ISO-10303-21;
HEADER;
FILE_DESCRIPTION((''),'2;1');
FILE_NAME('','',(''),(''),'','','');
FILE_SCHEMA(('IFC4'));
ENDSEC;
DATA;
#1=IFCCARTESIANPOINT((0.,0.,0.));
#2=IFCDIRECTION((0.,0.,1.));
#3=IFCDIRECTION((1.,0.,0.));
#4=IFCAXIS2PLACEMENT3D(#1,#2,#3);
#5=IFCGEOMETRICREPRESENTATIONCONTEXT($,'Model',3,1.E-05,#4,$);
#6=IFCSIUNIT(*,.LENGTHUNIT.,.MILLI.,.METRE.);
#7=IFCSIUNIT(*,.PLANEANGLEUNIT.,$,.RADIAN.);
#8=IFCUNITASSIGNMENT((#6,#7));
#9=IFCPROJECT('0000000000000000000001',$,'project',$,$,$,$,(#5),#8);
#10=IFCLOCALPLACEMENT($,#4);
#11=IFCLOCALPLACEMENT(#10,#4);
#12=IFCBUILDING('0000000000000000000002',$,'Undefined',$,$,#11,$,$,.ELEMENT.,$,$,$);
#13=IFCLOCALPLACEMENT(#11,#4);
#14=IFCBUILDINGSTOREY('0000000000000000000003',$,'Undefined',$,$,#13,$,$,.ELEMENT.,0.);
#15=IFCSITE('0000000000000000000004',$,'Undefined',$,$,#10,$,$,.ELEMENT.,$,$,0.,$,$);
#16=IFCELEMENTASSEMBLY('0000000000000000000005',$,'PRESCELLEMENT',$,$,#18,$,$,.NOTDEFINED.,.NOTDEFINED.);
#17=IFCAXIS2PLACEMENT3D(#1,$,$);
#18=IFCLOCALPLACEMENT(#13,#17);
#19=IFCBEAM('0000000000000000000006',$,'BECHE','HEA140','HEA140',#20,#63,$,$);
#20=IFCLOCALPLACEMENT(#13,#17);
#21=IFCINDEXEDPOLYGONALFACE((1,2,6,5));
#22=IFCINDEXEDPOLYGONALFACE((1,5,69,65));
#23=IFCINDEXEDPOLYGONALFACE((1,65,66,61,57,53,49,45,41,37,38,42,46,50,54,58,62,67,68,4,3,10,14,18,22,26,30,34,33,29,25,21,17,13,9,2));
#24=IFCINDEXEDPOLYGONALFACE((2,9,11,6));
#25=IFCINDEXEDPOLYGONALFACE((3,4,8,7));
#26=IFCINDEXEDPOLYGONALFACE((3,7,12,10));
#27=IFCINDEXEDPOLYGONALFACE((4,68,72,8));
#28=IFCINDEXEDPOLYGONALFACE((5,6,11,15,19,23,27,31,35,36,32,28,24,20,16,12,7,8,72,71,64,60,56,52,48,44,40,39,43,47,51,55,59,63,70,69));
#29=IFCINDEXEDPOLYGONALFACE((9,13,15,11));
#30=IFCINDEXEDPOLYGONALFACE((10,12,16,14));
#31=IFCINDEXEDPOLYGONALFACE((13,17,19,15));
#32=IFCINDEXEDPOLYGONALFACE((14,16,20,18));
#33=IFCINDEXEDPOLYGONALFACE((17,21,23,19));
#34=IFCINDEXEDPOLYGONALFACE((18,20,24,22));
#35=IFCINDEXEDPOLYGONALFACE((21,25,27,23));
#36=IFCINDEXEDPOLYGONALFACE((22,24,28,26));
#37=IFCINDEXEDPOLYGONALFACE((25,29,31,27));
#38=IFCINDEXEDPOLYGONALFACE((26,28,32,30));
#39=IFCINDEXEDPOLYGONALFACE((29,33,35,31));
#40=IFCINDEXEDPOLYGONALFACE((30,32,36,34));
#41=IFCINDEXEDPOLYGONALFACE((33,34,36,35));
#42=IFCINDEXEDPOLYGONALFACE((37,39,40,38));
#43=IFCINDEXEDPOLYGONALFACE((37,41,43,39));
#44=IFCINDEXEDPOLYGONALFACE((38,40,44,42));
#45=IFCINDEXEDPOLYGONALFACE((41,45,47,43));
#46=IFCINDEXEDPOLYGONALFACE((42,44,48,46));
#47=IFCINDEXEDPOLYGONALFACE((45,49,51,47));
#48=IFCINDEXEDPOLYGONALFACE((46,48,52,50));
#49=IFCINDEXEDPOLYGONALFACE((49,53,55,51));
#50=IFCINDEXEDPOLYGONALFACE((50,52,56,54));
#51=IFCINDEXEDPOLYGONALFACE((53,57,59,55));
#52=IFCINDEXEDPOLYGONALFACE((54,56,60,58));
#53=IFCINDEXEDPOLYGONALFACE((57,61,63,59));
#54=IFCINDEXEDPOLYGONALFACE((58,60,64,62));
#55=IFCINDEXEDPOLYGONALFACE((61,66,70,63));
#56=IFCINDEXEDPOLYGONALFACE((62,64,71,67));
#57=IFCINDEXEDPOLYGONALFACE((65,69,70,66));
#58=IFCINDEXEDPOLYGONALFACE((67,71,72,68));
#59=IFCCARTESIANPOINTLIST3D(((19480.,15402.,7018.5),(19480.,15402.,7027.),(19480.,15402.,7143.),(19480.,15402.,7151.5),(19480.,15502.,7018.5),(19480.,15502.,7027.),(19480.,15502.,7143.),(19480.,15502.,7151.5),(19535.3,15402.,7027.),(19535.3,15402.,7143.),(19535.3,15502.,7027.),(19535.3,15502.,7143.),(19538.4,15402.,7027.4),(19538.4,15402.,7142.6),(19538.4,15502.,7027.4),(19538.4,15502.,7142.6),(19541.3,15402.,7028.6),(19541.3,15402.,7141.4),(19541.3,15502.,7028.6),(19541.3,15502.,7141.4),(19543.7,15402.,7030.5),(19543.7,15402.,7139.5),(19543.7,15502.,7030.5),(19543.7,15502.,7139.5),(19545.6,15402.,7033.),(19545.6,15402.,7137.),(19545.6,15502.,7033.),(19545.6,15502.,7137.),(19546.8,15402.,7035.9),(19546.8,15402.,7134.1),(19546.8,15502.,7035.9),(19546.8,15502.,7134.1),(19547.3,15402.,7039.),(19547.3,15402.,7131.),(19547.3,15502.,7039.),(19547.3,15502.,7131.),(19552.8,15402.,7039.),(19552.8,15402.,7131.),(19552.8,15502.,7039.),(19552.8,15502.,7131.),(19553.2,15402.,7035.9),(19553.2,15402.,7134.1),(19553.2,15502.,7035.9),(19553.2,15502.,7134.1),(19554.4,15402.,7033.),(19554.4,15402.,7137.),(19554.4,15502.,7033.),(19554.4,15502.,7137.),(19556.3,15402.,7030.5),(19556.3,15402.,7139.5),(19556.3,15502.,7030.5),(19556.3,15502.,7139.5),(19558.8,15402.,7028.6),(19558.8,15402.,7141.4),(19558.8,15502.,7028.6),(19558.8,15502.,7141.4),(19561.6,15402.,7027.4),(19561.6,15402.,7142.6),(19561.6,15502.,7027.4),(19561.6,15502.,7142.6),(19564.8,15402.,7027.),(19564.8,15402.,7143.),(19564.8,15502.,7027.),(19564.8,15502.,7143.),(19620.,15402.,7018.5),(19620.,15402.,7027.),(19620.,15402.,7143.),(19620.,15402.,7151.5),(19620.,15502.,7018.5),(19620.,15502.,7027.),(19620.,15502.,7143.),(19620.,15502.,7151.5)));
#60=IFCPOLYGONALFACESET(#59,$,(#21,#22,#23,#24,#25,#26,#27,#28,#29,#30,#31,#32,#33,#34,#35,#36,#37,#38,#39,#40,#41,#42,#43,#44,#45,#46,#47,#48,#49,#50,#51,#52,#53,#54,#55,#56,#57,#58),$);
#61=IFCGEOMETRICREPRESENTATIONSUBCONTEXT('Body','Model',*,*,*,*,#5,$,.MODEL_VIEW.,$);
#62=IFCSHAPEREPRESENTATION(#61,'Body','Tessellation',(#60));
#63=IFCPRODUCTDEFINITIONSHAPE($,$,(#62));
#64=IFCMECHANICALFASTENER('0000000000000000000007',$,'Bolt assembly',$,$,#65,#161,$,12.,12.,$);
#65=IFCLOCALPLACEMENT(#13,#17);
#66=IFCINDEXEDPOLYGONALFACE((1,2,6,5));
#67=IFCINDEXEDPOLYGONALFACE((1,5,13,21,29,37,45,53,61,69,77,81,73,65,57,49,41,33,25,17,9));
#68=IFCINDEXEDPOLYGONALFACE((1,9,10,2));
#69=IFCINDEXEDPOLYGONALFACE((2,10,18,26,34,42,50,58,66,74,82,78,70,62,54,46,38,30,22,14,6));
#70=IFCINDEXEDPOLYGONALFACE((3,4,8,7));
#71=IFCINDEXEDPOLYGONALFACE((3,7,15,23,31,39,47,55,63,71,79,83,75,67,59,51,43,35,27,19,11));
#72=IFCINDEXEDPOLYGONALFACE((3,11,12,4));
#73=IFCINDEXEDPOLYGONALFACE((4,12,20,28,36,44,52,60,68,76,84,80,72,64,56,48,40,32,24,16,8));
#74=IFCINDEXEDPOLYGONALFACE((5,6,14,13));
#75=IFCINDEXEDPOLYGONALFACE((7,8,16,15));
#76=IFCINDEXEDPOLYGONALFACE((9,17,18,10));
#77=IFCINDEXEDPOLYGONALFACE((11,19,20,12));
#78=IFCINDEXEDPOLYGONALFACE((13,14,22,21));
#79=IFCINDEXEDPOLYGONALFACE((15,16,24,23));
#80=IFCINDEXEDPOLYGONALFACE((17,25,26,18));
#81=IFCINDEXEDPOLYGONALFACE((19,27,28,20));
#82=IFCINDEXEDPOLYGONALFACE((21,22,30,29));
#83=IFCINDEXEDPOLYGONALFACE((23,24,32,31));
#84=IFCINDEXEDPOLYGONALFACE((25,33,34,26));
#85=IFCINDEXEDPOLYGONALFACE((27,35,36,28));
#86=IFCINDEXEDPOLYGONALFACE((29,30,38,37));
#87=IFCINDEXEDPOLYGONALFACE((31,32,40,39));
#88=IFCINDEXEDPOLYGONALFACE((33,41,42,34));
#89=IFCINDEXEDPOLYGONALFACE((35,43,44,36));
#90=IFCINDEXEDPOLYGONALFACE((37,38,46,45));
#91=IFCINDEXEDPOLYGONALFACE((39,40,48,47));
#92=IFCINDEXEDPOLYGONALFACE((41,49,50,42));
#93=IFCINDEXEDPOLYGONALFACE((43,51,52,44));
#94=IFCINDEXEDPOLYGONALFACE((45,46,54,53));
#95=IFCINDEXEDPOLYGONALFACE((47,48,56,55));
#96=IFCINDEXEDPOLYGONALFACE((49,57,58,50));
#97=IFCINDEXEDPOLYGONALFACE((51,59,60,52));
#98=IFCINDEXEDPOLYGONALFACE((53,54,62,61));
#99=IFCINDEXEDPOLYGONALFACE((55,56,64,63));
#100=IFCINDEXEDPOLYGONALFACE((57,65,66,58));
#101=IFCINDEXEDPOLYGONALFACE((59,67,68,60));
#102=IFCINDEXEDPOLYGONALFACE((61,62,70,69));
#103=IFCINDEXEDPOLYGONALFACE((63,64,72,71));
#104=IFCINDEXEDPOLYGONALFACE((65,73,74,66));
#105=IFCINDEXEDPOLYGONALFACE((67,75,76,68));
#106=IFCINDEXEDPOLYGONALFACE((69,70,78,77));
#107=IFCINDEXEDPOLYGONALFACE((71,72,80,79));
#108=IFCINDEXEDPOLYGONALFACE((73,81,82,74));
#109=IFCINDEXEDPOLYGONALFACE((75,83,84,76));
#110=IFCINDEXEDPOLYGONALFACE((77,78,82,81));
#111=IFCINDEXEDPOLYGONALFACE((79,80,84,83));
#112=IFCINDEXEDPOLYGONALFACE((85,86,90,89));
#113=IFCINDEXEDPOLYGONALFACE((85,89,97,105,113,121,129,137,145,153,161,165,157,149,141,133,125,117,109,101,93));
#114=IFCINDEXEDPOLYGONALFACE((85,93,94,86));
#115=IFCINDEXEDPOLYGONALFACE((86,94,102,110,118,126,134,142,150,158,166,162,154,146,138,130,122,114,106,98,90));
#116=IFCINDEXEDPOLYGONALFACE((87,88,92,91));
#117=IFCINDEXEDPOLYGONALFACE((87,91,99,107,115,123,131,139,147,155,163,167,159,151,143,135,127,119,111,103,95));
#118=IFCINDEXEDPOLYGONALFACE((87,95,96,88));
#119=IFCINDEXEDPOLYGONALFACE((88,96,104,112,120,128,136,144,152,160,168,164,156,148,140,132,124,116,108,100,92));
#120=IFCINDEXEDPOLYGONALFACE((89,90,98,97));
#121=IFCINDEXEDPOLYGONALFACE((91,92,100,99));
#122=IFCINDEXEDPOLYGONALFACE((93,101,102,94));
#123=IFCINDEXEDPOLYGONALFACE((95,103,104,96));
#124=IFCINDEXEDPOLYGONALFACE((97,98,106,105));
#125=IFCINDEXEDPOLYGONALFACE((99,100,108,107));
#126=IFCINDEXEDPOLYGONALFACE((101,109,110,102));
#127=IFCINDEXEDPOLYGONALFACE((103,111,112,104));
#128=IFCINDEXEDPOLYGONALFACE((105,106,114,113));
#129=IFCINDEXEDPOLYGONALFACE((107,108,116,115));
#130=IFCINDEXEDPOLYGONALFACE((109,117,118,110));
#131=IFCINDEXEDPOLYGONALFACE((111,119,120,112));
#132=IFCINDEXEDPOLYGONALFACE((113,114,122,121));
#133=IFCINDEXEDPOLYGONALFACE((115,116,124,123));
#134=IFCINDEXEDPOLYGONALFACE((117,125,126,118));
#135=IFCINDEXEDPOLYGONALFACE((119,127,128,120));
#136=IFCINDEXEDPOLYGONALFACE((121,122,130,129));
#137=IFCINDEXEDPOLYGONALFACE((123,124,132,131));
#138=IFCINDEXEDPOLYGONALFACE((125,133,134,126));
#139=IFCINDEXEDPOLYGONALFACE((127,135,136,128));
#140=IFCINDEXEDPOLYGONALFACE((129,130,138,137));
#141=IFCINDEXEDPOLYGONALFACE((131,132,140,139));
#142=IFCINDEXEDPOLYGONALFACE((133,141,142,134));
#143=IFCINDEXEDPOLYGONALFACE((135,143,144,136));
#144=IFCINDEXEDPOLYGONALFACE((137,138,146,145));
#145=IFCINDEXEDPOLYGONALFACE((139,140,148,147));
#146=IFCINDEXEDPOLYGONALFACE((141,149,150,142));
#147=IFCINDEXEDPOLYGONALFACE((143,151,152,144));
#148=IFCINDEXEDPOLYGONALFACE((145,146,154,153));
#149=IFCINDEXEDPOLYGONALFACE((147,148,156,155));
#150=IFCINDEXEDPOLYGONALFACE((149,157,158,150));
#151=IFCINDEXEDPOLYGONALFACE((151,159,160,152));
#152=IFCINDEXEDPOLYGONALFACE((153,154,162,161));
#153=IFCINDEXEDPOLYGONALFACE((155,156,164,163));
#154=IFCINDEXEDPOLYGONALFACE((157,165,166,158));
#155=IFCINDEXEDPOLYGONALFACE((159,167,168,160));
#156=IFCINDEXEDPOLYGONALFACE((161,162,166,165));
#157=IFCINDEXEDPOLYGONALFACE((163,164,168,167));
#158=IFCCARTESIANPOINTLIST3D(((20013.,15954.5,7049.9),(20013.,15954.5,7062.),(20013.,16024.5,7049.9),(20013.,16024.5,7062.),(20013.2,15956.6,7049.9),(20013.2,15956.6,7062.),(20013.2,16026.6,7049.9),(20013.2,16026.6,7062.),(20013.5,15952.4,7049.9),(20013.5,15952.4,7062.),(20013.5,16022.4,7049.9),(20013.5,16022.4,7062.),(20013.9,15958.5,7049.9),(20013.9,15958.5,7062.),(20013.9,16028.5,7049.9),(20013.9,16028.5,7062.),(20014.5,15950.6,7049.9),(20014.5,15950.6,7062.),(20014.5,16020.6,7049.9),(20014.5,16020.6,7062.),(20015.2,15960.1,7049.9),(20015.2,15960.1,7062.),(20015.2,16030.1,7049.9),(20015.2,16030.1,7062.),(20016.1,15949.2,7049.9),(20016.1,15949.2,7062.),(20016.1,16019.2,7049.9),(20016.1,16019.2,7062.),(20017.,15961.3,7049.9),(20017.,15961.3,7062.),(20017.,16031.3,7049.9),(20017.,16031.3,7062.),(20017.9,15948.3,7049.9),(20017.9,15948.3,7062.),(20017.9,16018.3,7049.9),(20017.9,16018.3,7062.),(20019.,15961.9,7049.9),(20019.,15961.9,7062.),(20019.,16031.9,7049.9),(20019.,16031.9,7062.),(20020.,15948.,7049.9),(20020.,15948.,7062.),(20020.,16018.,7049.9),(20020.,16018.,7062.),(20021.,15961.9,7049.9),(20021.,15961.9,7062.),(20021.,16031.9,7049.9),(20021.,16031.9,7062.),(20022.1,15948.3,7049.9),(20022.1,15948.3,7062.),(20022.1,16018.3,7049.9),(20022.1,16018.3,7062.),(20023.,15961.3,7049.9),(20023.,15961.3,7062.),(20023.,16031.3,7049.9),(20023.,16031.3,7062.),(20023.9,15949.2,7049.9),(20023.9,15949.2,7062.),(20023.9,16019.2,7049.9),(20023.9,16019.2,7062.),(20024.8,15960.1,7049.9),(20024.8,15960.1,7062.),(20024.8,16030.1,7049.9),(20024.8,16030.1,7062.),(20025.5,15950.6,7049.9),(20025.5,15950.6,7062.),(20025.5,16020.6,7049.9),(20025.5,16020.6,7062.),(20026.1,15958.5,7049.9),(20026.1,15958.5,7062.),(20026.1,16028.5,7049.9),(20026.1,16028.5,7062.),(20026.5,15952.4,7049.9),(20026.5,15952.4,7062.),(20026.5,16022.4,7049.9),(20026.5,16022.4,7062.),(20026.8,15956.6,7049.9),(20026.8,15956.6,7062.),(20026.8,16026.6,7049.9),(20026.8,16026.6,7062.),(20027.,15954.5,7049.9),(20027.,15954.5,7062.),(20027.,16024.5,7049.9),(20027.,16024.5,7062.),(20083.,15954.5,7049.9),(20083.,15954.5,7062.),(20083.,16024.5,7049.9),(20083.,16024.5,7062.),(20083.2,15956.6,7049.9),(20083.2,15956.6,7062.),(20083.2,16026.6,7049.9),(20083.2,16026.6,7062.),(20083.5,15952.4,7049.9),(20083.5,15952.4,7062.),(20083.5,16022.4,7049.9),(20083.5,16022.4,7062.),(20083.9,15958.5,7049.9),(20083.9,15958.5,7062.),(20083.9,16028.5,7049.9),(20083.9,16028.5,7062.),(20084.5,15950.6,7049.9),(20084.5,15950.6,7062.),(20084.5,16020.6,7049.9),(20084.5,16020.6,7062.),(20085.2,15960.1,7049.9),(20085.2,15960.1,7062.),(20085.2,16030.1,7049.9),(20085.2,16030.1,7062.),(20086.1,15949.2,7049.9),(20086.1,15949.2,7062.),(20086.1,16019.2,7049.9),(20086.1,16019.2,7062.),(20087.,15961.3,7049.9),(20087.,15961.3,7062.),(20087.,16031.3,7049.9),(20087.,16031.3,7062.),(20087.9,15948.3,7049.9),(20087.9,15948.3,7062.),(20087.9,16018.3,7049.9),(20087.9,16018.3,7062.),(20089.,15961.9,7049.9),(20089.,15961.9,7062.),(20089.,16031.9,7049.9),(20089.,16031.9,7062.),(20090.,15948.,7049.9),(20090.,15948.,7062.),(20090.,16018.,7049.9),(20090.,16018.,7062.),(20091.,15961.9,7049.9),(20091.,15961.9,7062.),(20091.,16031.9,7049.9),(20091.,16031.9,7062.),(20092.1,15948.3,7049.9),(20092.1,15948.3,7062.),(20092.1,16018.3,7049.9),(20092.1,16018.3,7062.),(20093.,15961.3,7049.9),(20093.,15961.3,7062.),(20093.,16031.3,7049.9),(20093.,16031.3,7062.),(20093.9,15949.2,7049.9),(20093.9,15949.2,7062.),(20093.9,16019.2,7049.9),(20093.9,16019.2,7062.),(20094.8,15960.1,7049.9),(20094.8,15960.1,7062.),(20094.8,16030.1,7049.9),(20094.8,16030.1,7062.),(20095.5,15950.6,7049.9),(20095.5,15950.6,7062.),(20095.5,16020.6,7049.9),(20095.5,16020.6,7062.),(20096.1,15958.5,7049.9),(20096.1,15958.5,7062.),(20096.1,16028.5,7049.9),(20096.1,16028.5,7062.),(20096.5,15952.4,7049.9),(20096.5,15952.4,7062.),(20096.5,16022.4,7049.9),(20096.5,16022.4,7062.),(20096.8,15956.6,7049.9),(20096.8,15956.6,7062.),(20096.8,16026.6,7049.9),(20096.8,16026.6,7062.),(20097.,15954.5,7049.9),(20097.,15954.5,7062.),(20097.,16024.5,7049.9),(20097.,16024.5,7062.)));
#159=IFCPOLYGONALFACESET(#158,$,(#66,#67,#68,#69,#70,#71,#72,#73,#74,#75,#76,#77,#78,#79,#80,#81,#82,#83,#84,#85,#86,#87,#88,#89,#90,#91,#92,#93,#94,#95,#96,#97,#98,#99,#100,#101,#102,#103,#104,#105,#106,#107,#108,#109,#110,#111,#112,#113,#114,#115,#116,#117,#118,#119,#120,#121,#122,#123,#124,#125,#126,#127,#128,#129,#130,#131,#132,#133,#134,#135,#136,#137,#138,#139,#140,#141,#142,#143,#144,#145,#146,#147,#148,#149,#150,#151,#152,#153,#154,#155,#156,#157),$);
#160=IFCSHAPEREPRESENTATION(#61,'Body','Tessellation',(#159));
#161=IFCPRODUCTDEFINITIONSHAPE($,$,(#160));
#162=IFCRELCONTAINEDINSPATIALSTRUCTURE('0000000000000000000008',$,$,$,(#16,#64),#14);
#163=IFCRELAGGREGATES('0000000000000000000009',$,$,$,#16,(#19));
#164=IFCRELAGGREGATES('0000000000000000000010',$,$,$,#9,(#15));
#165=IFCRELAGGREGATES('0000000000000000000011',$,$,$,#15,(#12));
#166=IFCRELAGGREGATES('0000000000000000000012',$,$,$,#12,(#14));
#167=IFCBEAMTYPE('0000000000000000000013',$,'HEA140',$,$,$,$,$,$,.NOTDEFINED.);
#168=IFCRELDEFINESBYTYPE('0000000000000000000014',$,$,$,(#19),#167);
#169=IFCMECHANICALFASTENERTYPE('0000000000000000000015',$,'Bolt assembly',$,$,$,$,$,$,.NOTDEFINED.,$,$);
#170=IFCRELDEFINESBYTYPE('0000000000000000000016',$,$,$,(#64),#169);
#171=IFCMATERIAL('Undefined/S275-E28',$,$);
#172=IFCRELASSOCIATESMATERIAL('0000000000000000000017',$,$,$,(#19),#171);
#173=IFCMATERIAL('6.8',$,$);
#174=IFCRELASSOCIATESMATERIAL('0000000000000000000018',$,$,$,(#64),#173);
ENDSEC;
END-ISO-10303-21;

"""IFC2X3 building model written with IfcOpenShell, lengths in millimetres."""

from ifc_helpers import new_model, si_unit, frame, origin_with_axes, origin_2d_with_axis, place, context, subcontext, project, spatial, circle, i_section, extrude, source, transform, mapped, material, type_object, element, aggregate, save


model = new_model("IFC2X3")

# Units and contexts
model_context = context("Model", 3, precision=1e-05, world=origin_with_axes())
body_context = subcontext(model_context, "Body", "Model", "MODEL_VIEW")
ifc_project = project(units=[si_unit("LENGTHUNIT", "METRE", prefix="MILLI"), si_unit("PLANEANGLEUNIT", "RADIAN")], contexts=[model_context])

# Site, building, storey
site_placement = place(None, origin_with_axes())
site = spatial("IfcSite", under=ifc_project, at=site_placement, Name="Undefined", CompositionType="ELEMENT", RefElevation=0.0)
building_placement = place(site_placement, origin_with_axes())
building = spatial("IfcBuilding", under=site, at=building_placement, Name="Undefined", CompositionType="ELEMENT")
storey_placement = place(building_placement, origin_with_axes())
storey = spatial("IfcBuildingStorey", under=building, at=storey_placement, Name="Undefined", CompositionType="ELEMENT", Elevation=0.0)

# Shared definitions
ifc_material_1 = material(Name="Undefined/S275-E28")

# Element assembly, beam
assembly_1_placement = place(storey_placement, origin_with_axes())
assembly_1 = element("IfcElementAssembly", 1, at=assembly_1_placement, inside=storey, Name="PRESCELLEMENT", AssemblyPlace="NOTDEFINED", PredefinedType="NOTDEFINED")
beam_type_1 = type_object("IfcBeamType", Name="HEA140", PredefinedType="NOTDEFINED")
beam_1_placement = place(assembly_1_placement, frame((19550.0, 15402.0, 7085.0), z_axis=(0.0, 0.0, 1.0), x_axis=(0.0, 1.0, 0.0)))
beam_1 = element("IfcBeam", 2, at=beam_1_placement, type_object=beam_type_1, material=ifc_material_1, Name="BECHE", Description="HEA140", ObjectType="HEA140", context=body_context, shape_type="SweptSolid", body=[
    extrude(i_section(OverallWidth=140.0, OverallDepth=133.0, WebThickness=5.5, FlangeThickness=8.5, FilletRadius=12.0, at=origin_2d_with_axis()), frame((100.0, 0.0, 0.0), z_axis=(-1.0, 0.0, 0.0), x_axis=(0.0, -1.0, 0.0)), (0.0, 0.0, 1.0), 100.0),
])
aggregate(assembly_1, [beam_1])

# Mechanical fastener
ifc_material_2 = material(Name="6.8")
mechanical_fastener_type = type_object("IfcMechanicalFastenerType", Name="Bolt assembly")
shared_shape_1 = source(origin_with_axes(), body_context, "Body", "SweptSolid", [
    extrude(circle(Radius=7.0, at=origin_2d_with_axis()), frame((0.0, -12.0, 0.0), z_axis=(0.0, 1.0, 0.0), x_axis=(1.0, 0.0, 0.0)), (0.0, 0.0, 1.0), 12.1),
])
mechanical_fastener_1_placement = place(storey_placement, frame((20055.0, 16025.0, 7050.0), z_axis=(1.0, 0.0, 0.0), x_axis=(0.0, -1.0, 0.0)))
element("IfcMechanicalFastener", 3, at=mechanical_fastener_1_placement, inside=storey, type_object=mechanical_fastener_type, material=ifc_material_2, Name="Bolt assembly", NominalDiameter=12.0, NominalLength=12.0, context=body_context, shape_type="MappedRepresentation", body=[
    mapped(shared_shape_1, transform((0.0, 0.0, 35.0))),
    mapped(shared_shape_1, transform((70.0, 0.0, 35.0))),
    mapped(shared_shape_1, transform((0.0, 0.0, -35.0))),
    mapped(shared_shape_1, transform((70.0, 0.0, -35.0))),
])

save(model, "model.ifc")
